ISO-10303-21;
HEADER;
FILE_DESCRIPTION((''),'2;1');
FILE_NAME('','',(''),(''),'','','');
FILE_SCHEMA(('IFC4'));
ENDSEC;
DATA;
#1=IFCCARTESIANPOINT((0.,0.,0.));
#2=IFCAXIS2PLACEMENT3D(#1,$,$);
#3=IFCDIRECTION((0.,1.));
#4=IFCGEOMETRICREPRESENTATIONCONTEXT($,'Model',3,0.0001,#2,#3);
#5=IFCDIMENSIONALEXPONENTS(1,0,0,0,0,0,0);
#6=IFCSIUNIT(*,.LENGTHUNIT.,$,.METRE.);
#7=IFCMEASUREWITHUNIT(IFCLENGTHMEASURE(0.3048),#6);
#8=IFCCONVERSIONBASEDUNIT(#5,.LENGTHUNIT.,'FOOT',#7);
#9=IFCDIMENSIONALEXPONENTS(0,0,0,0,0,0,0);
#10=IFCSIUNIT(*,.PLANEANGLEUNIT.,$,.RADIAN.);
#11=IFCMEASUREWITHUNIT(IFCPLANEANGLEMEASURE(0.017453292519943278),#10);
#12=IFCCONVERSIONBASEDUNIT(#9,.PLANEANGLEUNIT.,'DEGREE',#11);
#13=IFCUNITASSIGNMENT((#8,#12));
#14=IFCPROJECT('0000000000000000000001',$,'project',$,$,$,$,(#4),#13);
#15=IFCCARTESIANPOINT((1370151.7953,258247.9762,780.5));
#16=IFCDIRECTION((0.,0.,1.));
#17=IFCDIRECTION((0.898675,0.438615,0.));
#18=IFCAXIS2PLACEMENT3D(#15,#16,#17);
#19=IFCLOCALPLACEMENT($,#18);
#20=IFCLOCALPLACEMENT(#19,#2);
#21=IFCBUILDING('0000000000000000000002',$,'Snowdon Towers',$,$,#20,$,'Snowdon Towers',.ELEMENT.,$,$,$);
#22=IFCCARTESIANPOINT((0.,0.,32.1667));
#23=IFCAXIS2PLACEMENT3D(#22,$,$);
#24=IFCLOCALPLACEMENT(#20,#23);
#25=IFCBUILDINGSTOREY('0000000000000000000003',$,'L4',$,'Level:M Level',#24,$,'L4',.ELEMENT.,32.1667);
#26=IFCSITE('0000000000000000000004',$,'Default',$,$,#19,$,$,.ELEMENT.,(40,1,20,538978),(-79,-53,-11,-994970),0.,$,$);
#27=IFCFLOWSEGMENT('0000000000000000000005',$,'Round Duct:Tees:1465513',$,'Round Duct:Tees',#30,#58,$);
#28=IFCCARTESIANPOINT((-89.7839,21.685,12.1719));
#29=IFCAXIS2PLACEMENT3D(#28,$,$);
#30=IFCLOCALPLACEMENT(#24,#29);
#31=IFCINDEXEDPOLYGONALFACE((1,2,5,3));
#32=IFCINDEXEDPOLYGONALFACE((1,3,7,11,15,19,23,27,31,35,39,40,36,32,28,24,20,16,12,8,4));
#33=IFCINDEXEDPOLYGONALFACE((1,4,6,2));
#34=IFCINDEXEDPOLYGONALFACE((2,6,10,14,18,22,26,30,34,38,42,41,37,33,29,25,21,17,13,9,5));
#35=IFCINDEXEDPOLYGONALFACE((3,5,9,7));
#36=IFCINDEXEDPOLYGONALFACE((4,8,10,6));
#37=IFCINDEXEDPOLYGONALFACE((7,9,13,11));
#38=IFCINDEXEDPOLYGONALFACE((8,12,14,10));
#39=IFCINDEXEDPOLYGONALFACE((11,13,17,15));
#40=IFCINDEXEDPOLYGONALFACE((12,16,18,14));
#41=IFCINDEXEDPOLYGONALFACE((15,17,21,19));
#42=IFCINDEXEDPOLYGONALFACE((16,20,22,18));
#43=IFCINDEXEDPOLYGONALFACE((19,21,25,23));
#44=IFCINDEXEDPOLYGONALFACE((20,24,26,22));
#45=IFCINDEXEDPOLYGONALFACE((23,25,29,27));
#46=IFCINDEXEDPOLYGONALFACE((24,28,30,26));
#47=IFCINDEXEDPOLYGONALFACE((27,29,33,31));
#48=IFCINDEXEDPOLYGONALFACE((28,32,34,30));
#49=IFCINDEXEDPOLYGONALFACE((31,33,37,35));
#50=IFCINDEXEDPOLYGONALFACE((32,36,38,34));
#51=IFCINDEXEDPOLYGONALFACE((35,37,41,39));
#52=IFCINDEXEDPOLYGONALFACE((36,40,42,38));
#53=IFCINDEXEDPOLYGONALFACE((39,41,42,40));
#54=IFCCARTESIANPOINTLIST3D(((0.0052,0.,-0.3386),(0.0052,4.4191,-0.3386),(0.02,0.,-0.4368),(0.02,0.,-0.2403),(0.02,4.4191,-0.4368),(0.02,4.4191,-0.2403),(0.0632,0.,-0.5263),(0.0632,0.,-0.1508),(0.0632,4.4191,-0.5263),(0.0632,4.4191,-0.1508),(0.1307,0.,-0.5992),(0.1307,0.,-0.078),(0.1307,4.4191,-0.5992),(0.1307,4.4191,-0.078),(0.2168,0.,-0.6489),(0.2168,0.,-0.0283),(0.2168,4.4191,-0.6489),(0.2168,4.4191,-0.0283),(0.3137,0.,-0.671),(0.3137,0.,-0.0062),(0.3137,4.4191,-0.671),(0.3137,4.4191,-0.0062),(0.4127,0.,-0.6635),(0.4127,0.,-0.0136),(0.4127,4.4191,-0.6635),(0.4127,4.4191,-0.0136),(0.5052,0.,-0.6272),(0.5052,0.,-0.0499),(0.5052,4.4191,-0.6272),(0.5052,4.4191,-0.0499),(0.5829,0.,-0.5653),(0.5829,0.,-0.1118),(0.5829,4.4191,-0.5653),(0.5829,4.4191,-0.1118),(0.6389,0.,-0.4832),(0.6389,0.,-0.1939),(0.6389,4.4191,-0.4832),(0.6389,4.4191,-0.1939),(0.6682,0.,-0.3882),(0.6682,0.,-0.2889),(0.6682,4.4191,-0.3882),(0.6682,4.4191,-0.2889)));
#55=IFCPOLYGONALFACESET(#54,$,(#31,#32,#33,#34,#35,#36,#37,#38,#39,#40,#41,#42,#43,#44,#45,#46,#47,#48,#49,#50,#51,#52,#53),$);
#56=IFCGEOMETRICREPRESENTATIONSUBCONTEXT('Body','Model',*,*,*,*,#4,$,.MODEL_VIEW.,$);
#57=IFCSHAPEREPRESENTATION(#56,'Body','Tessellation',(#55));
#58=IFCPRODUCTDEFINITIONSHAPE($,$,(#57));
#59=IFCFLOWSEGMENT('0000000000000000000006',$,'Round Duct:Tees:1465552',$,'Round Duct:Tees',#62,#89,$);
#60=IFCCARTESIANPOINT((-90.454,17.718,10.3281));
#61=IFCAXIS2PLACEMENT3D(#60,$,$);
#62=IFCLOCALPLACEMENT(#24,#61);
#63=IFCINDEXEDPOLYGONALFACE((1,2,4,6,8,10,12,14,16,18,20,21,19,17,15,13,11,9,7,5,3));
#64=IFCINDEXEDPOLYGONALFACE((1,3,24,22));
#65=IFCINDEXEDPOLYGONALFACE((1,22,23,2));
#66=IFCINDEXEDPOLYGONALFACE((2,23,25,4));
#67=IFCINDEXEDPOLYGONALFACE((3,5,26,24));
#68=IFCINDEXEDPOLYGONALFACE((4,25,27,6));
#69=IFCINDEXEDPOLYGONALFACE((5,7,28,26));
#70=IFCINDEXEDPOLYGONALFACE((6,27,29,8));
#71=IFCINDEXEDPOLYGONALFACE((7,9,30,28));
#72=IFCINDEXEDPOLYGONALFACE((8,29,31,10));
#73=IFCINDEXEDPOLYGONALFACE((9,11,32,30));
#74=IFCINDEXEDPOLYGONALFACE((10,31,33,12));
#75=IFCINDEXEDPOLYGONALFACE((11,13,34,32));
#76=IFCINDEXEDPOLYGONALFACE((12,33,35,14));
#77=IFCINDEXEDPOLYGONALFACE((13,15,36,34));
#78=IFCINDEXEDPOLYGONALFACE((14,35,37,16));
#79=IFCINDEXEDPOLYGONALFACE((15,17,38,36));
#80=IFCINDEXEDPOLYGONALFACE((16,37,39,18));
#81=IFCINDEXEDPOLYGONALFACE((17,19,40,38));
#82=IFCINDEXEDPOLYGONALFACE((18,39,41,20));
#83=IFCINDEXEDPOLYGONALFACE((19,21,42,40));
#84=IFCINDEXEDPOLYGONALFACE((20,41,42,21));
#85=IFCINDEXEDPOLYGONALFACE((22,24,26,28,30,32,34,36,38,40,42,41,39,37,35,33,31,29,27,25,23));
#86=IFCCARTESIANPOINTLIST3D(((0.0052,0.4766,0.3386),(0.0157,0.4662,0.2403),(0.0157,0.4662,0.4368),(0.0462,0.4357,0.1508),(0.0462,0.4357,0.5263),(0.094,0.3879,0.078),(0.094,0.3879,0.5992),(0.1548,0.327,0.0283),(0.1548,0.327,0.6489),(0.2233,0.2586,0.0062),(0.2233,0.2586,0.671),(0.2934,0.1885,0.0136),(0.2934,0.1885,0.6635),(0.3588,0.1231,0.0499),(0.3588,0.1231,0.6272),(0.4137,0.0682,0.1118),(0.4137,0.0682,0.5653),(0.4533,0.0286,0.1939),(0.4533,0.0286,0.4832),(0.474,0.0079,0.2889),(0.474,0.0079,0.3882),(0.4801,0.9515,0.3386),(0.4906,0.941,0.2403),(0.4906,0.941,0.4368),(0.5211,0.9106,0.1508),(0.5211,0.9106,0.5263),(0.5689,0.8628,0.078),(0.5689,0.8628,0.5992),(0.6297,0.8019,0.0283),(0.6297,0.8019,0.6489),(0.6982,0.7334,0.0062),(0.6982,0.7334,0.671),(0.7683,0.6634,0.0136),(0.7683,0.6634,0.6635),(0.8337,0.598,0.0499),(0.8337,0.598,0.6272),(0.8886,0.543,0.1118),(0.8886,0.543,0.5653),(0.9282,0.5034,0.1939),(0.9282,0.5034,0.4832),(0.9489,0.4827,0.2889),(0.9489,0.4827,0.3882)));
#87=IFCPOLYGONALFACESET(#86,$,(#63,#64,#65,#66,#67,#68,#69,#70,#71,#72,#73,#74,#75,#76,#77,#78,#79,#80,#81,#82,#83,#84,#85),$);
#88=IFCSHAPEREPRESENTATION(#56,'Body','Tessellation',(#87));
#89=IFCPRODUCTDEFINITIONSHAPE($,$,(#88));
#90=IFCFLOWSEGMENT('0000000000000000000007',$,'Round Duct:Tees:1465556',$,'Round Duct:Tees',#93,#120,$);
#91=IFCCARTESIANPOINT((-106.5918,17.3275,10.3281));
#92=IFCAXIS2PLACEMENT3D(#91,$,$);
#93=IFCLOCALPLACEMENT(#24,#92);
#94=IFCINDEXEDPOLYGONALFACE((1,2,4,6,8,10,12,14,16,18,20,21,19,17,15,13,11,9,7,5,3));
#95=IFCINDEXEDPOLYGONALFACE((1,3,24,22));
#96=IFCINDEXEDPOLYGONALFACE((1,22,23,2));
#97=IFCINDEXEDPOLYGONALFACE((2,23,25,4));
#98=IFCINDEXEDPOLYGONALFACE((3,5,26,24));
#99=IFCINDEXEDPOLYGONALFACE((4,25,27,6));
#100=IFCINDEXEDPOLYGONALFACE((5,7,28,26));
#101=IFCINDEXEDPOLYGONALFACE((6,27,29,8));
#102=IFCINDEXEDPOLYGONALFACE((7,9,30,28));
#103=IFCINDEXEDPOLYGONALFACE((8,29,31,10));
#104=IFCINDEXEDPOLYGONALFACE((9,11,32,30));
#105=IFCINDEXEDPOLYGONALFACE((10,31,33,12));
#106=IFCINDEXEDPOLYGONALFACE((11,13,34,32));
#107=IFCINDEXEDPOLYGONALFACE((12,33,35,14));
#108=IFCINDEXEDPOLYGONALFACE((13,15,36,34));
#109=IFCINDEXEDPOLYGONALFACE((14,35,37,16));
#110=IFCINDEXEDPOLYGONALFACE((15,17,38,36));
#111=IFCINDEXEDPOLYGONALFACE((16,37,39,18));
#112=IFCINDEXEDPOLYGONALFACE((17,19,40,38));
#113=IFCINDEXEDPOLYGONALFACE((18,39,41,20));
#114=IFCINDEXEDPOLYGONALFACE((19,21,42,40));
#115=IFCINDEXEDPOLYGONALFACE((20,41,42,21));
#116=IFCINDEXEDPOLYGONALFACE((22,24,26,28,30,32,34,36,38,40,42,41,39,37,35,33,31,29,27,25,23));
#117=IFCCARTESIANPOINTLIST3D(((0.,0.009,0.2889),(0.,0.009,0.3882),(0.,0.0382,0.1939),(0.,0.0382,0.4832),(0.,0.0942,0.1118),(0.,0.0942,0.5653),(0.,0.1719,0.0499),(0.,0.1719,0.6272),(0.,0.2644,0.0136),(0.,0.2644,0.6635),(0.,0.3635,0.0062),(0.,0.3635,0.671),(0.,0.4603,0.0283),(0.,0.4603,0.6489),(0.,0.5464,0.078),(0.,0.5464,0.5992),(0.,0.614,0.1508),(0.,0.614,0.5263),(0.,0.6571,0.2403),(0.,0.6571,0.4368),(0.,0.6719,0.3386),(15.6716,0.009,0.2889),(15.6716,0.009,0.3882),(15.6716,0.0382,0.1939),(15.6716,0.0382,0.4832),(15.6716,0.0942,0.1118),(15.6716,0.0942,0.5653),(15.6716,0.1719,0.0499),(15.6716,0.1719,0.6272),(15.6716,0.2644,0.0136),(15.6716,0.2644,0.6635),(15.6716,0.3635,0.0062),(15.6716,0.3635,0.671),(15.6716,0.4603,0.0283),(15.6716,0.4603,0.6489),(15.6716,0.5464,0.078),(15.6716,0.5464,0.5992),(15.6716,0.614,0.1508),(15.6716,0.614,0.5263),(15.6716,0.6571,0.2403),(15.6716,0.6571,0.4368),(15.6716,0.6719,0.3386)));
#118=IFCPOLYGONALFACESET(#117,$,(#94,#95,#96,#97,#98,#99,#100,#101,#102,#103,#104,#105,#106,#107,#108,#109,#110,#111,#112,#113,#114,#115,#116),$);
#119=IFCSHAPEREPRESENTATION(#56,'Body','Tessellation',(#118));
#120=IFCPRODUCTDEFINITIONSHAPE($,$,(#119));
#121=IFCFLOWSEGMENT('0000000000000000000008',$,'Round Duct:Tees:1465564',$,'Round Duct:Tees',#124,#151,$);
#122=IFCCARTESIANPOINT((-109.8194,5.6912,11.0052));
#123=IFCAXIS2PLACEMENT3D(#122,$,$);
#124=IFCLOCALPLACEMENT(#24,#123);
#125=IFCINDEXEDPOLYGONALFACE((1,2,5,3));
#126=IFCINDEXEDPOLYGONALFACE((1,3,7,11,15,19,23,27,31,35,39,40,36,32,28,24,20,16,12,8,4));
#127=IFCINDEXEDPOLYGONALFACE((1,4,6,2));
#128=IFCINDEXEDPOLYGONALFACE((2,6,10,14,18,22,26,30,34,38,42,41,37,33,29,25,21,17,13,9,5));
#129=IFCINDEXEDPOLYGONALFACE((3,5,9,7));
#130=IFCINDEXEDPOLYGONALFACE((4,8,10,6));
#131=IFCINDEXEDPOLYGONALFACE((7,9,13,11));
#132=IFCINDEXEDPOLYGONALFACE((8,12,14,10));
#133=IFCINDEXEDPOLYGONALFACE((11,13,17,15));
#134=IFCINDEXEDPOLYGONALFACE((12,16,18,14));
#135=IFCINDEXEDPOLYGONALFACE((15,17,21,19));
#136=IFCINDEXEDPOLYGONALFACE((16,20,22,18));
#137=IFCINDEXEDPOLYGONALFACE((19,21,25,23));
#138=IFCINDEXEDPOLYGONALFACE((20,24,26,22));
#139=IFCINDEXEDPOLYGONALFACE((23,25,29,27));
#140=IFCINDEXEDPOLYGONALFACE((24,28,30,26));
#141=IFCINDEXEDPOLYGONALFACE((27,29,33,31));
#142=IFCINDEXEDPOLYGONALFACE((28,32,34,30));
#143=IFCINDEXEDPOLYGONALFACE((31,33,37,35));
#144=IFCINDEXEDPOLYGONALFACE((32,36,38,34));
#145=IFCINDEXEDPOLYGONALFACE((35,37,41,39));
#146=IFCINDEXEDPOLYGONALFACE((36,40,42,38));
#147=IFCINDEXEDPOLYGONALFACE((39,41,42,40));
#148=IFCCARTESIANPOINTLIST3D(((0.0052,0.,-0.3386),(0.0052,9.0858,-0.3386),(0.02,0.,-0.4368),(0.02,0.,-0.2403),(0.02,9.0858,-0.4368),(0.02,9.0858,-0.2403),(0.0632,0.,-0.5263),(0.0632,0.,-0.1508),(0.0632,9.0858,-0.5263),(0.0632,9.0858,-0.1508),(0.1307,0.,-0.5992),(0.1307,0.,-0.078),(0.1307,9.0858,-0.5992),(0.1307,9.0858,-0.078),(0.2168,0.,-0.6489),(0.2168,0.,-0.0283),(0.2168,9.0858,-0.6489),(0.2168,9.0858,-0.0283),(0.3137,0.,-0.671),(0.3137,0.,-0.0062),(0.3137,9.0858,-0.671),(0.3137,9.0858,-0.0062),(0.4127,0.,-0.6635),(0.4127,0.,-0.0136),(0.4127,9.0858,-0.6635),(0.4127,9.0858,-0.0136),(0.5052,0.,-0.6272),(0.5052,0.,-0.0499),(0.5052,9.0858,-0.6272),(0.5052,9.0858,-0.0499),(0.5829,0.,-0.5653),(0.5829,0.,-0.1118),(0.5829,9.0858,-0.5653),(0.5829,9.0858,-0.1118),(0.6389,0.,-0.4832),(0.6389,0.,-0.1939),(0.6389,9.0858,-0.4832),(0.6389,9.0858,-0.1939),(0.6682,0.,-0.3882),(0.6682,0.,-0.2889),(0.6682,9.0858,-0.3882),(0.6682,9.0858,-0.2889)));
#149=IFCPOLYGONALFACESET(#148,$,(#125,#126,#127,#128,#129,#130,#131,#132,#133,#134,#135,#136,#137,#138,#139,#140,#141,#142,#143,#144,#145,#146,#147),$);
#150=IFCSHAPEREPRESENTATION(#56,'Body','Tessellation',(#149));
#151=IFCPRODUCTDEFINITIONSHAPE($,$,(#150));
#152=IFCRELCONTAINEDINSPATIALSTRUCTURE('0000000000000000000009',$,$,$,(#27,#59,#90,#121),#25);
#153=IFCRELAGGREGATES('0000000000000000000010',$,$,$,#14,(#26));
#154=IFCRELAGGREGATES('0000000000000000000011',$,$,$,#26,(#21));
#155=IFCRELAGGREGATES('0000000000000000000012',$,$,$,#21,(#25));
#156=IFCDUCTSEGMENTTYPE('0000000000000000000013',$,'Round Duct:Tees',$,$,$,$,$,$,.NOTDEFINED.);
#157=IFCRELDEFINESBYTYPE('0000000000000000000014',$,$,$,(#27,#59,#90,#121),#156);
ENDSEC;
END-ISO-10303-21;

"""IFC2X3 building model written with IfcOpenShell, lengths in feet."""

from ifc_helpers import new_model, entity, si_unit, converted_unit, direction, frame, frame_2d, origin, origin_2d_with_axis, place, context, subcontext, project, spatial, circle, extrude, type_object, element, save


model = new_model("IFC2X3")

# Units and contexts
model_context = context("Model", 3, precision=0.0001, world=origin(), true_north=direction((0.0, 1.0)))
body_context = subcontext(model_context, "Body", "Model", "MODEL_VIEW")
ifc_project = project(units=[converted_unit("LENGTHUNIT", "FOOT", entity("IfcLengthMeasure", 0.3048), si_unit("LENGTHUNIT", "METRE"), dimensions=[1, 0, 0, 0, 0, 0, 0]), converted_unit("PLANEANGLEUNIT", "DEGREE", entity("IfcPlaneAngleMeasure", 0.017453292519943278), si_unit("PLANEANGLEUNIT", "RADIAN"), dimensions=[0, 0, 0, 0, 0, 0, 0])], contexts=[model_context])

# Site, building, storey
site_placement = place(None, frame((1370151.7953, 258247.9762, 780.5), z_axis=(0.0, 0.0, 1.0), x_axis=(0.898675, 0.438615, 0.0)))
site = spatial("IfcSite", under=ifc_project, at=site_placement, Name="Default", CompositionType="ELEMENT", RefLatitude=(40, 1, 20, 538978), RefLongitude=(-79, -53, -11, -994970), RefElevation=0.0)
building_placement = place(site_placement, origin())
building = spatial("IfcBuilding", under=site, at=building_placement, Name="Snowdon Towers", LongName="Snowdon Towers", CompositionType="ELEMENT")
storey_placement = place(building_placement, frame((0.0, 0.0, 32.1667)))
storey = spatial("IfcBuildingStorey", under=building, at=storey_placement, Name="L4", ObjectType="Level:M Level", LongName="L4", CompositionType="ELEMENT", Elevation=32.1667)

# Flow segments
duct_segment_type = type_object("IfcDuctSegmentType", Name="Round Duct:Tees", PredefinedType="NOTDEFINED")
flow_segment_1_placement = place(storey_placement, frame((-89.7839, 21.685, 12.1719)))
element("IfcFlowSegment", 1, at=flow_segment_1_placement, inside=storey, type_object=duct_segment_type, Name="Round Duct:Tees:1465513", ObjectType="Round Duct:Tees", context=body_context, shape_type="SweptSolid", body=[
    extrude(circle(Radius=0.3333, at=frame_2d((0.0, 0.0), x_axis=(1.0, 0.0))), frame((0.3386, 0.0, -0.3386), z_axis=(0.0, 1.0, 0.0), x_axis=(-1.0, 0.0, 0.0)), (0.0, 0.0, 1.0), 4.4191),
])
flow_segment_2_placement = place(storey_placement, frame((-90.454, 17.718, 10.3281)))
element("IfcFlowSegment", 2, at=flow_segment_2_placement, inside=storey, type_object=duct_segment_type, Name="Round Duct:Tees:1465552", ObjectType="Round Duct:Tees", context=body_context, shape_type="SweptSolid", body=[
    extrude(circle(Radius=0.3333, at=origin_2d_with_axis()), frame((0.2409, 0.2409, 0.3386), z_axis=(0.707107, 0.707107, 0.0), x_axis=(-0.707107, 0.707107, 0.0)), (0.0, 0.0, 1.0), 0.6716),
])
flow_segment_3_placement = place(storey_placement, frame((-106.5918, 17.3275, 10.3281)))
element("IfcFlowSegment", 3, at=flow_segment_3_placement, inside=storey, type_object=duct_segment_type, Name="Round Duct:Tees:1465556", ObjectType="Round Duct:Tees", context=body_context, shape_type="SweptSolid", body=[
    extrude(circle(Radius=0.3333, at=frame_2d((0.0, 0.0), x_axis=(1.0, 0.0))), frame((0.0, 0.3386, 0.3386), z_axis=(1.0, 0.0, 0.0), x_axis=(0.0, 1.0, 0.0)), (0.0, 0.0, 1.0), 15.6716),
])
flow_segment_4_placement = place(storey_placement, frame((-109.8194, 5.6912, 11.0052)))
element("IfcFlowSegment", 4, at=flow_segment_4_placement, inside=storey, type_object=duct_segment_type, Name="Round Duct:Tees:1465564", ObjectType="Round Duct:Tees", context=body_context, shape_type="SweptSolid", body=[
    extrude(circle(Radius=0.3333, at=frame_2d((0.0, 0.0), x_axis=(1.0, 0.0))), frame((0.3386, 0.0, -0.3386), z_axis=(0.0, 1.0, 0.0), x_axis=(-1.0, 0.0, 0.0)), (0.0, 0.0, 1.0), 9.0858),
])

save(model, "model.ifc")
